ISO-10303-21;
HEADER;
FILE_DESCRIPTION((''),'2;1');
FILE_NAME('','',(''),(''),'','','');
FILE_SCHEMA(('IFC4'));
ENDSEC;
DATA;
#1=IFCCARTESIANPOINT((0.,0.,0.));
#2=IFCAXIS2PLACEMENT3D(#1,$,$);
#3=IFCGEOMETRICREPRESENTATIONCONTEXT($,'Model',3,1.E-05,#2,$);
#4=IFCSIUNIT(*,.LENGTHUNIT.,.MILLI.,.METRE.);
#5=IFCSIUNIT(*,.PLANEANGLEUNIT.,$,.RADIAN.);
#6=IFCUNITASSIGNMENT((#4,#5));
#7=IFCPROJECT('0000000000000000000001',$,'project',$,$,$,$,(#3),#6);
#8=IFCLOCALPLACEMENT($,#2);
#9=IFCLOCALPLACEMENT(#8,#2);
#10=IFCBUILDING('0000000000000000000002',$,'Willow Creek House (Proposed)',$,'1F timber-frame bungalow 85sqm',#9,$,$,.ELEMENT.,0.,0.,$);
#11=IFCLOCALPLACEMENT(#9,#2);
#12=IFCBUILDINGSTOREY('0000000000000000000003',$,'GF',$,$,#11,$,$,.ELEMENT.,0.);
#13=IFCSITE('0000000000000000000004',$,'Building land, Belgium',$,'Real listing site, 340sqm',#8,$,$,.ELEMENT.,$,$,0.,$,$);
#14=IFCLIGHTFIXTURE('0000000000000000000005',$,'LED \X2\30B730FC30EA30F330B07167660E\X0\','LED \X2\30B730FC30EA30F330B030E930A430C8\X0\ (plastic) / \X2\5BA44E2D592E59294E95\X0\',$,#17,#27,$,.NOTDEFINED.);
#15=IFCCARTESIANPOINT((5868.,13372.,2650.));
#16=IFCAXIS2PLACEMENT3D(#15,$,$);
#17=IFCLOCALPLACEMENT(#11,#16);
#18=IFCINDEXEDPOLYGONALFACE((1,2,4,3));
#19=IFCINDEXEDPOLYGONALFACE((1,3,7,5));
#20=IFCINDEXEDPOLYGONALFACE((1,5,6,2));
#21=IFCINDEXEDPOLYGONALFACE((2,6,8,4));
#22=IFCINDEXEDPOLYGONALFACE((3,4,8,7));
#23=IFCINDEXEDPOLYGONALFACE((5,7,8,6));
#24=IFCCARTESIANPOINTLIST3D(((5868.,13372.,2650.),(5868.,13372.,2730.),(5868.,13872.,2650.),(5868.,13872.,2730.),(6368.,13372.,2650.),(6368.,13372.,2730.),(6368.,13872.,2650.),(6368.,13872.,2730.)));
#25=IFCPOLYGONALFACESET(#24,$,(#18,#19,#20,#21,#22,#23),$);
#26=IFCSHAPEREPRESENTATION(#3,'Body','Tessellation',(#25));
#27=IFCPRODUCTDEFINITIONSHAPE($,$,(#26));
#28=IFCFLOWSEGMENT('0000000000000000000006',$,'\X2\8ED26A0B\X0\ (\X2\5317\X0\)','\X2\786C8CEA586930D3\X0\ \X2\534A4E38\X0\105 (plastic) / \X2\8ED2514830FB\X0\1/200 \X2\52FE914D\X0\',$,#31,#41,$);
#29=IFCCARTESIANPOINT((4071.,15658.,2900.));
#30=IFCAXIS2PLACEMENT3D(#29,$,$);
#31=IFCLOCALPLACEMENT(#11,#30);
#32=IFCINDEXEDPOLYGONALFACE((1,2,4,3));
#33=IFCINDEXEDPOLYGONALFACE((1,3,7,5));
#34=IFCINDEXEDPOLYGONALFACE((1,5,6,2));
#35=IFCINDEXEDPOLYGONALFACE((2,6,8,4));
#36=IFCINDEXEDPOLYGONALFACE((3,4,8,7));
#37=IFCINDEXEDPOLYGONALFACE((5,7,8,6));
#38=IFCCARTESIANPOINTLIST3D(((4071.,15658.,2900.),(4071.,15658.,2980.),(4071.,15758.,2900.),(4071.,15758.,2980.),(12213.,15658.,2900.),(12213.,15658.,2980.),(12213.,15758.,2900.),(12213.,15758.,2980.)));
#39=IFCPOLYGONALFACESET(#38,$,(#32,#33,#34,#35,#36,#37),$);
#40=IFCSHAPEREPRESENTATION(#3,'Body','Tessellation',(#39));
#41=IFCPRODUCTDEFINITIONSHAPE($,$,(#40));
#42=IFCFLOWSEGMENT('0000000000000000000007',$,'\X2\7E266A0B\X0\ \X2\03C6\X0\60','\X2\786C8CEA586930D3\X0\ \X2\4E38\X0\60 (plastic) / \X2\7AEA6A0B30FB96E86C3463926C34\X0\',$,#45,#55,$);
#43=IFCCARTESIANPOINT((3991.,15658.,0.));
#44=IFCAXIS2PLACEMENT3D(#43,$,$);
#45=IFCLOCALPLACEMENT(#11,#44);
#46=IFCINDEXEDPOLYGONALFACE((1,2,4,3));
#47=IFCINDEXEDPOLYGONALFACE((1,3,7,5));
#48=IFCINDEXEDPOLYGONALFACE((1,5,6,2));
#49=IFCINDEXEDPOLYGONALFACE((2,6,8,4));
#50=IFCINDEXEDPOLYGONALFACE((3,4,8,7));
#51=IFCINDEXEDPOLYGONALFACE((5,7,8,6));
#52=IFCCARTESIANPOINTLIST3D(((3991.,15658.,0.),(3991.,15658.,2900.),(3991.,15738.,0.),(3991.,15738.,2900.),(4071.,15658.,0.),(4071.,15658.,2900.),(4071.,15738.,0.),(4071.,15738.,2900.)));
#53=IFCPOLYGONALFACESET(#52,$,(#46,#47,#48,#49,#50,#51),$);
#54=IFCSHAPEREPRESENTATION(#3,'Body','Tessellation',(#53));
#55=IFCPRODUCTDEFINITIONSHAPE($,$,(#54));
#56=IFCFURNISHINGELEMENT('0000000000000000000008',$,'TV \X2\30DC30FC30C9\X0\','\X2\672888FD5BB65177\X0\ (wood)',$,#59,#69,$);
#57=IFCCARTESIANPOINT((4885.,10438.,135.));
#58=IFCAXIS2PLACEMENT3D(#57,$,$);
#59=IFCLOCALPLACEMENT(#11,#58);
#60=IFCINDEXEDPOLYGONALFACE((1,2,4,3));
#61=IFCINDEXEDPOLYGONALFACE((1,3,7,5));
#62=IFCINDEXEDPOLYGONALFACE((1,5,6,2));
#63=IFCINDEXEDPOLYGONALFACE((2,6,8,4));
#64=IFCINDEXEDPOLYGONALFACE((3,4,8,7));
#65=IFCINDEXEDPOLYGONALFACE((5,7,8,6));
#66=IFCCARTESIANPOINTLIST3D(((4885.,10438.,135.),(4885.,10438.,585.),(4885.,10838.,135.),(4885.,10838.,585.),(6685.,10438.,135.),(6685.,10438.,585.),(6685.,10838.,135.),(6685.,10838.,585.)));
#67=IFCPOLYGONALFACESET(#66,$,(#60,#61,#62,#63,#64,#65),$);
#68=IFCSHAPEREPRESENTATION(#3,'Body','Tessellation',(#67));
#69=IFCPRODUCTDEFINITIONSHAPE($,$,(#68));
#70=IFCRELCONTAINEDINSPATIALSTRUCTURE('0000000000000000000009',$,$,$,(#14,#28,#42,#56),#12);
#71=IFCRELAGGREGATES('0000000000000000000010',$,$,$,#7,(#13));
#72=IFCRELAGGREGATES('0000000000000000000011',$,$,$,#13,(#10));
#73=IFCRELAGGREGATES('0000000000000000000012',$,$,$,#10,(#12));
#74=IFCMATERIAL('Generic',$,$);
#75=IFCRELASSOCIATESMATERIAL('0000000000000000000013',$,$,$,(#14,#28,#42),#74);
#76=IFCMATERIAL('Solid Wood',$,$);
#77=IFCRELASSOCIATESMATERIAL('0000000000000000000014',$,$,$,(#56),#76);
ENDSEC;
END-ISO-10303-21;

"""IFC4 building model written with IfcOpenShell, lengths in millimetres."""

from ifc_helpers import new_model, si_unit, frame, frame_2d, origin, place, context, project, spatial, rectangle, extrude, material, element, save


model = new_model("IFC4")

# Units and contexts
model_context = context("Model", 3, precision=1e-05, world=origin())
ifc_project = project(units=[si_unit("LENGTHUNIT", "METRE", prefix="MILLI"), si_unit("PLANEANGLEUNIT", "RADIAN")], contexts=[model_context])

# Site, building, storey
site_placement = place(None, origin())
site = spatial("IfcSite", under=ifc_project, at=site_placement, Name="Building land, Belgium", ObjectType="Real listing site, 340sqm", CompositionType="ELEMENT", RefElevation=0.0)
building_placement = place(site_placement, origin())
building = spatial("IfcBuilding", under=site, at=building_placement, Name="Willow Creek House (Proposed)", ObjectType="1F timber-frame bungalow 85sqm", CompositionType="ELEMENT", ElevationOfRefHeight=0.0, ElevationOfTerrain=0.0)
storey_placement = place(building_placement, origin())
storey = spatial("IfcBuildingStorey", under=building, at=storey_placement, Name="GF", CompositionType="ELEMENT", Elevation=0.0)

# Shared definitions
ifc_material_1 = material(Name="Solid Wood")

# Shared definitions
ifc_material_2 = material(Name="Generic")

# Light fixture
light_fixture_placement = place(storey_placement, frame((5868.0, 13372.0, 2650.0)))
element("IfcLightFixture", 1, at=light_fixture_placement, inside=storey, material=ifc_material_2, Name="LED シーリング照明", Description="LED シーリングライト (plastic) / 室中央天井", PredefinedType="NOTDEFINED", context=model_context, shape_type="SweptSolid", body=[
    extrude(rectangle(XDim=500.0, YDim=500.0, at=frame_2d((250.0, 250.0))), frame((5868.0, 13372.0, 2650.0)), (0.0, 0.0, 1.0), 80.0),
])

# Flow segments
flow_segment_1_placement = place(storey_placement, frame((4071.0, 15658.0, 2900.0)))
element("IfcFlowSegment", 2, at=flow_segment_1_placement, inside=storey, material=ifc_material_2, Name="軒樋 (北)", Description="硬質塩ビ 半丸105 (plastic) / 軒先・1/200 勾配", context=model_context, shape_type="SweptSolid", body=[
    extrude(rectangle(XDim=8142.0, YDim=100.0, at=frame_2d((4071.0, 50.0))), frame((4071.0, 15658.0, 2900.0)), (0.0, 0.0, 1.0), 80.0),
])
flow_segment_2_placement = place(storey_placement, frame((3991.0, 15658.0, 0.0)))
element("IfcFlowSegment", 3, at=flow_segment_2_placement, inside=storey, material=ifc_material_2, Name="縦樋 φ60", Description="硬質塩ビ 丸60 (plastic) / 竪樋・雨水排水", context=model_context, shape_type="SweptSolid", body=[
    extrude(rectangle(XDim=80.0, YDim=80.0, at=frame_2d((40.0, 40.0))), frame((3991.0, 15658.0, 0.0)), (0.0, 0.0, 1.0), 2900.0),
])

# Furnishing element
furnishing_placement = place(storey_placement, frame((4885.0, 10438.0, 135.0)))
element("IfcFurnishingElement", 4, at=furnishing_placement, inside=storey, material=ifc_material_1, Name="TV ボード", Description="木製家具 (wood)", context=model_context, shape_type="SweptSolid", body=[
    extrude(rectangle(XDim=1800.0, YDim=400.0, at=frame_2d((900.0, 200.0))), frame((4885.0, 10438.0, 135.0)), (0.0, 0.0, 1.0), 450.0),
])

save(model, "model.ifc")
